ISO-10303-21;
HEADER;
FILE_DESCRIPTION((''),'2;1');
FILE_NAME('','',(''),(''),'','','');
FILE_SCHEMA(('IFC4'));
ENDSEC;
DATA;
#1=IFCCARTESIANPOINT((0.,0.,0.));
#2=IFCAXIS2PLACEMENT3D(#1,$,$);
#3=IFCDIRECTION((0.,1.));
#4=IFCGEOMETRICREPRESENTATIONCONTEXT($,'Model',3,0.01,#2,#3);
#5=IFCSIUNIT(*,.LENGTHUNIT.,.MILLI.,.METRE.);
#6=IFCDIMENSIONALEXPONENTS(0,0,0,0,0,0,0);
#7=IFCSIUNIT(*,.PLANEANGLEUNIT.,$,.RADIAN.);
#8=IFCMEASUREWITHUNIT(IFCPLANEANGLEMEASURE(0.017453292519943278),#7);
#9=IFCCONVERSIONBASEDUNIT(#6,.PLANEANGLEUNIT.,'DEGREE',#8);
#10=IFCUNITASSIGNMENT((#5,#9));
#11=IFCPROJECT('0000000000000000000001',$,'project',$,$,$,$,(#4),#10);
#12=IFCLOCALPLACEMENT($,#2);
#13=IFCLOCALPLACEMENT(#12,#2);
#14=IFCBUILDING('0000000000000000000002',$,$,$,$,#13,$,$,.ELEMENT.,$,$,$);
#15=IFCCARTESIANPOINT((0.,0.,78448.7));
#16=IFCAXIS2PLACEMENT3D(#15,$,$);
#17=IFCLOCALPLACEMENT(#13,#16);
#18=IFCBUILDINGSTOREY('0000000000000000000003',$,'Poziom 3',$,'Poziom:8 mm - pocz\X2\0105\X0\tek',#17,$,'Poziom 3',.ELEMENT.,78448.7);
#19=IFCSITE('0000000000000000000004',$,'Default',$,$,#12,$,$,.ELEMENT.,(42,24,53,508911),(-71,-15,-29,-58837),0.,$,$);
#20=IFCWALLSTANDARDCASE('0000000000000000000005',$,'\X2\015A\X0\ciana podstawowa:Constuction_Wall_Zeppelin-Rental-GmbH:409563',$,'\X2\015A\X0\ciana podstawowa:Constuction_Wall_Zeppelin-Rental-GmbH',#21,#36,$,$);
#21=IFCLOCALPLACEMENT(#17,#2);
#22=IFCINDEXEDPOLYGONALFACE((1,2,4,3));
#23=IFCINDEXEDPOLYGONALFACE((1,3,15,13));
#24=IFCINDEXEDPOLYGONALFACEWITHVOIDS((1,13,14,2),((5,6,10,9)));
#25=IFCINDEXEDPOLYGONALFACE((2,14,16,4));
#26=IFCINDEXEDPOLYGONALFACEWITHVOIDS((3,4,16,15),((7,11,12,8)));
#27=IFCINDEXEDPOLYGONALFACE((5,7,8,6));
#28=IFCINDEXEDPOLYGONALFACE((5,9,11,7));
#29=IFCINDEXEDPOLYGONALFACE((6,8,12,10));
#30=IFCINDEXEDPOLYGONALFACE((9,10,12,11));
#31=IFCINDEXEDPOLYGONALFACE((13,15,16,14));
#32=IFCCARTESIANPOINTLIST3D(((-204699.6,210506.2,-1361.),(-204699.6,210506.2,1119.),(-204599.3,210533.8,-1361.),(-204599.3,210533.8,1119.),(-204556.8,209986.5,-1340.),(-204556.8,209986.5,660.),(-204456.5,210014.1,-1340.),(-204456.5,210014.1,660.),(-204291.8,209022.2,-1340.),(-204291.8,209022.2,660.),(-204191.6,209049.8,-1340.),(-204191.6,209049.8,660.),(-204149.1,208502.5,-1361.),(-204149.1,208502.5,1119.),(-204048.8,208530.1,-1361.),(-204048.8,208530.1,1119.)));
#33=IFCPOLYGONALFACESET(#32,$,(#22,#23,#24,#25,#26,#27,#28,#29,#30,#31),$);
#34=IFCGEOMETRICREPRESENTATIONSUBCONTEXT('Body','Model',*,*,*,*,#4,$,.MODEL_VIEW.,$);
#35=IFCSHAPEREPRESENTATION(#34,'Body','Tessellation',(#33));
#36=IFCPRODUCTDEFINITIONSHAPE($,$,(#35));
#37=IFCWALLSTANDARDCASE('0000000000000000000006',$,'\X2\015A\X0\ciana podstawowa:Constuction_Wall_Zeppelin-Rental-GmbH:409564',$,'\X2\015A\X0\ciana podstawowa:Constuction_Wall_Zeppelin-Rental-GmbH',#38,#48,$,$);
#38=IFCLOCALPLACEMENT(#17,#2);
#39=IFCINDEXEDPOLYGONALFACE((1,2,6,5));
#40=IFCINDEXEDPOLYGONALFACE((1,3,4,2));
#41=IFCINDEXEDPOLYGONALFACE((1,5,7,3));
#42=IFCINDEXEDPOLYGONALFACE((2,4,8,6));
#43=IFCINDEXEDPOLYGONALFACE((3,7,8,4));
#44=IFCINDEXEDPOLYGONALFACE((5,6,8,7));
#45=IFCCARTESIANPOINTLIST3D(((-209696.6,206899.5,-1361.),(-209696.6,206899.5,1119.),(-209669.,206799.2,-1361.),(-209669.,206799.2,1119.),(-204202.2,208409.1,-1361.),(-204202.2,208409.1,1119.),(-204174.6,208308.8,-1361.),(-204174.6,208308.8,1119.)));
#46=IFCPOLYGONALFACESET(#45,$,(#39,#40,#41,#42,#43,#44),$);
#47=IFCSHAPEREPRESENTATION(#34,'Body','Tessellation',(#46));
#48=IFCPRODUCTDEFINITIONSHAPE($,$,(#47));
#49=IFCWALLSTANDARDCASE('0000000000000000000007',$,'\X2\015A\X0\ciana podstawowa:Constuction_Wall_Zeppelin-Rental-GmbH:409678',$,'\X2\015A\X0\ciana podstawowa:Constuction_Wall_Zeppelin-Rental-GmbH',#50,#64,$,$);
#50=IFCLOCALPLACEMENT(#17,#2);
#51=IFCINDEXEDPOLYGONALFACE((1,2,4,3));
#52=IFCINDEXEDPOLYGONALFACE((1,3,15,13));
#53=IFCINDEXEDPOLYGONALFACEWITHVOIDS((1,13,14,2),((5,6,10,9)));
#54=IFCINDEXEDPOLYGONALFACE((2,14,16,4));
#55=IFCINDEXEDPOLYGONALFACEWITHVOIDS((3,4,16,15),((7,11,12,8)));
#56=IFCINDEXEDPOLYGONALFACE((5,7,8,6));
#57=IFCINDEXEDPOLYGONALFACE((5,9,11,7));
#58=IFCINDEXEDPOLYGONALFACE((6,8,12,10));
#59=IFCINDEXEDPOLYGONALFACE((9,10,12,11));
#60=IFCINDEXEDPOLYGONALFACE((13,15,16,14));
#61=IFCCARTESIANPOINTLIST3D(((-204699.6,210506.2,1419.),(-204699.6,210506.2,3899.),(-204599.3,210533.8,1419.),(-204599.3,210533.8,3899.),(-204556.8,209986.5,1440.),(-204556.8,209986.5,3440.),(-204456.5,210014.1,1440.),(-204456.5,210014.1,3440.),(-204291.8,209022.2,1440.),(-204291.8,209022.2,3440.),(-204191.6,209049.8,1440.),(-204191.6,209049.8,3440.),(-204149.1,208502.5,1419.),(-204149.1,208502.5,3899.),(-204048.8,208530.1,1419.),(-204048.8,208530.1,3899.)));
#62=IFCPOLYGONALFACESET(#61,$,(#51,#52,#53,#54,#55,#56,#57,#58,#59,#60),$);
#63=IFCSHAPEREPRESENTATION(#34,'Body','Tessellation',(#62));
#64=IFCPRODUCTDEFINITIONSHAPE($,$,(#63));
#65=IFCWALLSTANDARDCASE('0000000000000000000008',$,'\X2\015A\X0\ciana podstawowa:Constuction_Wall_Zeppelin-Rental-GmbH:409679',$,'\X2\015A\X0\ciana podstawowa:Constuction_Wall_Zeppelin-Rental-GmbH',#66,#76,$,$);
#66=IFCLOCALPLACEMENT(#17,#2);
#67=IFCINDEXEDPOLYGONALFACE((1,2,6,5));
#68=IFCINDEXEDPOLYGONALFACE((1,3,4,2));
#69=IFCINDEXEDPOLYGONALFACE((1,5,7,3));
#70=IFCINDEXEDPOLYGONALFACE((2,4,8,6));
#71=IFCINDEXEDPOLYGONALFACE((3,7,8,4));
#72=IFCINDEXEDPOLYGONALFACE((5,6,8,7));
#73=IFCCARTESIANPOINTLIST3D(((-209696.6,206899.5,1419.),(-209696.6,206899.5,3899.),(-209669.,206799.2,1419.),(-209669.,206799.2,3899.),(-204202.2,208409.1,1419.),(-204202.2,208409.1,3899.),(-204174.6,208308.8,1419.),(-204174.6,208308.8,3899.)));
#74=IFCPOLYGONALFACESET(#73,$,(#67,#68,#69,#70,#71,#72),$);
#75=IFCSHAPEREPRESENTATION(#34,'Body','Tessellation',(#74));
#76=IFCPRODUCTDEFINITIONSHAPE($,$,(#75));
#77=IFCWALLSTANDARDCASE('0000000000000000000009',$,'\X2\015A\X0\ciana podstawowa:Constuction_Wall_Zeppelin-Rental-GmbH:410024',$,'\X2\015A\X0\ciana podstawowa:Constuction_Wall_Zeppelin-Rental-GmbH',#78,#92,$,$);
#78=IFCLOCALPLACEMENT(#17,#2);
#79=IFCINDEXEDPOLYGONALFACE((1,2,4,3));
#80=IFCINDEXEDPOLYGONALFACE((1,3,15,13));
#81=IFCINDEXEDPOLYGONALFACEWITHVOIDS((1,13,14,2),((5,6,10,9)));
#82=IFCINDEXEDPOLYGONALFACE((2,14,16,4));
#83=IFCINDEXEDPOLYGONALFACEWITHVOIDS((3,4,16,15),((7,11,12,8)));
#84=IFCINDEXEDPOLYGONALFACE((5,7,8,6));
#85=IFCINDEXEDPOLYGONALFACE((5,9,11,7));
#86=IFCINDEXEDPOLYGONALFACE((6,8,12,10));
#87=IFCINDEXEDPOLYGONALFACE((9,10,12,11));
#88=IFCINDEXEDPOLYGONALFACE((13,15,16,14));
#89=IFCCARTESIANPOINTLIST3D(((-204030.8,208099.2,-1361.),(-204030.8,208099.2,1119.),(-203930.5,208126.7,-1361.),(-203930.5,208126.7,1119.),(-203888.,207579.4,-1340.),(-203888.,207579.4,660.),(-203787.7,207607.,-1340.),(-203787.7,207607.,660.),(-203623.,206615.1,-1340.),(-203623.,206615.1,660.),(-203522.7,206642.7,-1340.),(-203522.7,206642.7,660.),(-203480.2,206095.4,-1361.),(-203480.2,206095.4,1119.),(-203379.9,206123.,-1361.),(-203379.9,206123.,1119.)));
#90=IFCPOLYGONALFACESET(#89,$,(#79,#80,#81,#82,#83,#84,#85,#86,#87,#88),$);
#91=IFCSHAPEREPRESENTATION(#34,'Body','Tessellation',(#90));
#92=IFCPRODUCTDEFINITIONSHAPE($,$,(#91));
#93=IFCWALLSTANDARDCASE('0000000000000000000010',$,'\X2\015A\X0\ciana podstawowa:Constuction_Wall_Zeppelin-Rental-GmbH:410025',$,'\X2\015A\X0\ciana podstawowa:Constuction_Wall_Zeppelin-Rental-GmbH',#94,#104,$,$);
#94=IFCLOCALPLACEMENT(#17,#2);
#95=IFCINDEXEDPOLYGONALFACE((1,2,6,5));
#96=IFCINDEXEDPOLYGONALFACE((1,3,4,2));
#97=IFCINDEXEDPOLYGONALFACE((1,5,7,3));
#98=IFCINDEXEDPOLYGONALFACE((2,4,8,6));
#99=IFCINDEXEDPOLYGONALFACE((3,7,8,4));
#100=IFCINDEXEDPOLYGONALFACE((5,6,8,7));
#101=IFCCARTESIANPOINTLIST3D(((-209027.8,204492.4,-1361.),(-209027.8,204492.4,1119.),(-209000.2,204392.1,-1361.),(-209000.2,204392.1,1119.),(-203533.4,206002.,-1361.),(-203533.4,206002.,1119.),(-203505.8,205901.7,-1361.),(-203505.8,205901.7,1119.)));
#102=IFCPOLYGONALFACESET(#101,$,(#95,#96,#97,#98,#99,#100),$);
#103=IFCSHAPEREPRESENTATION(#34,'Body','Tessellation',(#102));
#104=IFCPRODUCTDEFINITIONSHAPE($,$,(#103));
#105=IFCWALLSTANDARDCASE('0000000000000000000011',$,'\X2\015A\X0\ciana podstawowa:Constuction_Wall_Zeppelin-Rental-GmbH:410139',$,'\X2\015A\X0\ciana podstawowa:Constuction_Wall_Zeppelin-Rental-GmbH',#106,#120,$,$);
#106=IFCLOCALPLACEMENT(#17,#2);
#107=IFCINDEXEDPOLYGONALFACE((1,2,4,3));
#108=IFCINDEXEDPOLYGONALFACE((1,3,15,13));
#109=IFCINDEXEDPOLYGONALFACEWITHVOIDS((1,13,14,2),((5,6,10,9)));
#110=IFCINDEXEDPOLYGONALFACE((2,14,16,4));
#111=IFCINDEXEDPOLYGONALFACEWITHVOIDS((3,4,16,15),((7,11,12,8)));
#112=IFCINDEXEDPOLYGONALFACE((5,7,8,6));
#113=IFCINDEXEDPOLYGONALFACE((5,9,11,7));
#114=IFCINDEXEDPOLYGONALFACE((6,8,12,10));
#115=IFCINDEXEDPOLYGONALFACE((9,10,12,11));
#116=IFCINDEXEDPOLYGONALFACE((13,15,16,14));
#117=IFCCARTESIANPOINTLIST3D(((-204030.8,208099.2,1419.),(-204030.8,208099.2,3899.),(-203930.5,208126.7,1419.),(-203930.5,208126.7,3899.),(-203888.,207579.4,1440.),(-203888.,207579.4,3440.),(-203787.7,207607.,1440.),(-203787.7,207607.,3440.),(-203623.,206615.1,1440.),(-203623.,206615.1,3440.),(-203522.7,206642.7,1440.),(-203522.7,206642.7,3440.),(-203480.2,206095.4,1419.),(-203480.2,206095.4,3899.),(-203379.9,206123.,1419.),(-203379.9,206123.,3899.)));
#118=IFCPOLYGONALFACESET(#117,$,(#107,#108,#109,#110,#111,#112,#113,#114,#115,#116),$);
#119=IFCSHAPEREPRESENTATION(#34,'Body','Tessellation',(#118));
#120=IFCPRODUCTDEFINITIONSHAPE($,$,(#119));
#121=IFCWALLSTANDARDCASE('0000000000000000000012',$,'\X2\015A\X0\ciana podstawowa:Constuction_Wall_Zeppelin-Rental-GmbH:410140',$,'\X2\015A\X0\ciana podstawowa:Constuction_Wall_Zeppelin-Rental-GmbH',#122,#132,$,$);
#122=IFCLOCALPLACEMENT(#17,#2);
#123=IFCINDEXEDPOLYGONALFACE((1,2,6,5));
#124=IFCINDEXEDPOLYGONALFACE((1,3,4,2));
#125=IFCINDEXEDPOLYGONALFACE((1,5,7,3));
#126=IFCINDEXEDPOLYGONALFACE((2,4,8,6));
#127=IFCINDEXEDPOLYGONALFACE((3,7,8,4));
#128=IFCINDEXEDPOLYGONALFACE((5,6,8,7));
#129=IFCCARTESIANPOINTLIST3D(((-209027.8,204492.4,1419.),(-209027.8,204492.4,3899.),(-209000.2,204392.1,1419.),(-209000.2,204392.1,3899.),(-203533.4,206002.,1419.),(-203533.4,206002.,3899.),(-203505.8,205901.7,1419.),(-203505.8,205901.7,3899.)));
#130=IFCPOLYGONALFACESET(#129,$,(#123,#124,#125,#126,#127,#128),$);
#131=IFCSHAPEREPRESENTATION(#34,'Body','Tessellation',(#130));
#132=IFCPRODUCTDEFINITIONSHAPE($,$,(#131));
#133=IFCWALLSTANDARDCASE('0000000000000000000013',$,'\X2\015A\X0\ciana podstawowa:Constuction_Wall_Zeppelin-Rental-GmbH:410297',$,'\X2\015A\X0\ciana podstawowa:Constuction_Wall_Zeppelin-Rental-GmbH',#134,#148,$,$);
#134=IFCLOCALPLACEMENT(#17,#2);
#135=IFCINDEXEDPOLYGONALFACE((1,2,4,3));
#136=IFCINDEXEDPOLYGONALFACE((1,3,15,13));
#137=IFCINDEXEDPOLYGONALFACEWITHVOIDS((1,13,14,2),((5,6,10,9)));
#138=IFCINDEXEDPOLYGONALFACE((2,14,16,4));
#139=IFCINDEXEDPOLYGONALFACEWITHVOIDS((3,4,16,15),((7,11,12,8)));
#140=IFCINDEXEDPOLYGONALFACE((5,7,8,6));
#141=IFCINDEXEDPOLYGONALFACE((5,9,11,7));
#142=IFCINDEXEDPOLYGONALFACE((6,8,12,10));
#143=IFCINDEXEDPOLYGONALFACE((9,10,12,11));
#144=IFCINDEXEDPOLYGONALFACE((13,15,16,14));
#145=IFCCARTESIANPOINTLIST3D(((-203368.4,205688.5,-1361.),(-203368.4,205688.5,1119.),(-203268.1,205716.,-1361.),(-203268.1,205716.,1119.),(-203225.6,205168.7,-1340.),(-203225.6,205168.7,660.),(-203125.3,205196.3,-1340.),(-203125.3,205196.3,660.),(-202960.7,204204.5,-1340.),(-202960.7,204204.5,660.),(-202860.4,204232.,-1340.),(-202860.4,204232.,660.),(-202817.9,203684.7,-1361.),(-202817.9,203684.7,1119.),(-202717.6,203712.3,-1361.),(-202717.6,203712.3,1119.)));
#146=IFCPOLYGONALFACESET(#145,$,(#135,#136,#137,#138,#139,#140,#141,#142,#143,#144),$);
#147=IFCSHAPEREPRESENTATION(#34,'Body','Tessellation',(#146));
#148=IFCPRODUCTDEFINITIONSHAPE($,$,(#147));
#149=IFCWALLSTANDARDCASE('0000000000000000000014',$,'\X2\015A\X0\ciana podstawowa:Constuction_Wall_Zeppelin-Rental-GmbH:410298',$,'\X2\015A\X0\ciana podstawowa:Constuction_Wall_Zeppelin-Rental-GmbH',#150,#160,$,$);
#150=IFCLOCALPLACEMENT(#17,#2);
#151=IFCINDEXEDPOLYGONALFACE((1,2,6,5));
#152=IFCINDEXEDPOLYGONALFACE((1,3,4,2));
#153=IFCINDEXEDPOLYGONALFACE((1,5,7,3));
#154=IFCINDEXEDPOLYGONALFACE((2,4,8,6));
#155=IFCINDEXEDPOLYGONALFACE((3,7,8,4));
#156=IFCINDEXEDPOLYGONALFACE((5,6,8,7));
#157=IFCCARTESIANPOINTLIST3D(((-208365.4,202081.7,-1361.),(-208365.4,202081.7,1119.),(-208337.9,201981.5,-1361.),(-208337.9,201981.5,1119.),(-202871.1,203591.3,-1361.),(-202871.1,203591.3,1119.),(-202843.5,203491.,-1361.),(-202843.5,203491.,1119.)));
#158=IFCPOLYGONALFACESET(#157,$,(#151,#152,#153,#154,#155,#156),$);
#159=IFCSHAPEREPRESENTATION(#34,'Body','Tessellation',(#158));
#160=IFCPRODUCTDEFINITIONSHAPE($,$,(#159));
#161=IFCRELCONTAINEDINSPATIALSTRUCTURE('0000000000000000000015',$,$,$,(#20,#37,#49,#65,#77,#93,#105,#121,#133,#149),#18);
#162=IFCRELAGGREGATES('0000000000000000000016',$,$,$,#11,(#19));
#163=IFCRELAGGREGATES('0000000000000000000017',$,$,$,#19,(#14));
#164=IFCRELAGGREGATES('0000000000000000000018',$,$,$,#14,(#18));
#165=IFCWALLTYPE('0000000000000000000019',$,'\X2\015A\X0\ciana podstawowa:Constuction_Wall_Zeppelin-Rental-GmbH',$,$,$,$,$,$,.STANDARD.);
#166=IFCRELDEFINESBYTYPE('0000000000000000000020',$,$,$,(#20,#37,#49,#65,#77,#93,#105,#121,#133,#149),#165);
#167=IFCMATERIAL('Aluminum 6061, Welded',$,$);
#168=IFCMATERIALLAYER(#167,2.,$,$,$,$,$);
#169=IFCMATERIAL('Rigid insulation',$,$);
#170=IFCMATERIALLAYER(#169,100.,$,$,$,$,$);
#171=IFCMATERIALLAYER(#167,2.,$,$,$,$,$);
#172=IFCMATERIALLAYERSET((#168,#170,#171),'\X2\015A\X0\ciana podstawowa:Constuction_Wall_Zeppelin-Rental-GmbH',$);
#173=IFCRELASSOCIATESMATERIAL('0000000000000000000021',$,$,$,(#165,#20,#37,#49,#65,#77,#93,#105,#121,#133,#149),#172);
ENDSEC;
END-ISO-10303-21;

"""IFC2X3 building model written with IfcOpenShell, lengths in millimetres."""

from ifc_helpers import new_model, entity, si_unit, converted_unit, direction, frame, frame_2d, origin, place, context, subcontext, project, spatial, rectangle, extrude, material, layer, layer_set, layer_usage, type_object, element, save


model = new_model("IFC2X3")

# Units and contexts
model_context = context("Model", 3, precision=0.01, world=origin(), true_north=direction((0.0, 1.0)))
body_context = subcontext(model_context, "Body", "Model", "MODEL_VIEW")
ifc_project = project(units=[si_unit("LENGTHUNIT", "METRE", prefix="MILLI"), converted_unit("PLANEANGLEUNIT", "DEGREE", entity("IfcPlaneAngleMeasure", 0.017453292519943278), si_unit("PLANEANGLEUNIT", "RADIAN"), dimensions=[0, 0, 0, 0, 0, 0, 0])], contexts=[model_context])

# Site, building, storey
site_placement = place(None, origin())
site = spatial("IfcSite", under=ifc_project, at=site_placement, Name="Default", CompositionType="ELEMENT", RefLatitude=(42, 24, 53, 508911), RefLongitude=(-71, -15, -29, -58837), RefElevation=0.0)
building_placement = place(site_placement, origin())
building = spatial("IfcBuilding", under=site, at=building_placement, CompositionType="ELEMENT")
storey_placement = place(building_placement, frame((0.0, 0.0, 78448.7)))
storey = spatial("IfcBuildingStorey", under=building, at=storey_placement, Name="Poziom 3", ObjectType="Poziom:8 mm - początek", LongName="Poziom 3", CompositionType="ELEMENT", Elevation=78448.7)

# Wall, opening
ifc_material_1 = material(Name="Aluminum 6061, Welded")
ifc_layer_1 = layer(ifc_material_1, 2.0)
ifc_material_2 = material(Name="Rigid insulation")
ifc_layer_2 = layer(ifc_material_2, 100.0)
ifc_layer_3 = layer(ifc_material_1, 2.0)
ifc_layer_set = layer_set([ifc_layer_1, ifc_layer_2, ifc_layer_3], Name="Ściana podstawowa:Constuction_Wall_Zeppelin-Rental-GmbH")
ifc_layer_usage_1 = layer_usage(ifc_layer_set, "AXIS2", "NEGATIVE", 52.0)
wall_type = type_object("IfcWallType", Name="Ściana podstawowa:Constuction_Wall_Zeppelin-Rental-GmbH", PredefinedType="STANDARD", material=ifc_layer_set)
wall_1_placement = place(storey_placement, frame((-204649.4, 210520.0, -1361.0), z_axis=(0.0, 0.0, 1.0), x_axis=(0.264931, -0.964267, 0.0)))
wall_1 = element("IfcWallStandardCase", 1, at=wall_1_placement, inside=storey, type_object=wall_type, material=ifc_layer_usage_1, Name="Ściana podstawowa:Constuction_Wall_Zeppelin-Rental-GmbH:409563", ObjectType="Ściana podstawowa:Constuction_Wall_Zeppelin-Rental-GmbH", context=body_context, shape_type="SweptSolid", body=[
    extrude(rectangle(XDim=2078.0, YDim=104.0, at=frame_2d((1039.0, 0.0), x_axis=(-1.0, 0.0))), origin(), (0.0, 0.0, 1.0), 2480.0),
])
opening_1_placement = place(wall_1_placement, frame((539.0, -52.0, 21.0)))
element("IfcOpeningElement", 2, at=opening_1_placement, cuts=wall_1, ObjectType="Opening", context=body_context, shape_type="SweptSolid", body=[
    extrude(rectangle(XDim=2000.0, YDim=1000.0, at=frame_2d((1000.0, 500.0), x_axis=(1.0, 0.0))), frame((0.0, 0.0, 0.0), z_axis=(0.0, 1.0, 0.0), x_axis=(0.0, 0.0, 1.0)), (0.0, 0.0, 1.0), 104.0),
])

# Wall
ifc_layer_usage_2 = layer_usage(ifc_layer_set, "AXIS2", "NEGATIVE", 52.0)
wall_2_placement = place(storey_placement, frame((-204188.4, 208358.9, -1361.0), z_axis=(0.0, 0.0, 1.0), x_axis=(-0.964267, -0.264931, 0.0)))
element("IfcWallStandardCase", 3, at=wall_2_placement, inside=storey, type_object=wall_type, material=ifc_layer_usage_2, Name="Ściana podstawowa:Constuction_Wall_Zeppelin-Rental-GmbH:409564", ObjectType="Ściana podstawowa:Constuction_Wall_Zeppelin-Rental-GmbH", context=body_context, shape_type="SweptSolid", body=[
    extrude(rectangle(XDim=5698.0, YDim=104.0, at=frame_2d((2849.0, 0.0), x_axis=(-1.0, 0.0))), origin(), (0.0, 0.0, 1.0), 2480.0),
])

# Wall, opening
ifc_layer_usage_3 = layer_usage(ifc_layer_set, "AXIS2", "NEGATIVE", 52.0)
wall_3_placement = place(storey_placement, frame((-204649.4, 210520.0, 1419.0), z_axis=(0.0, 0.0, 1.0), x_axis=(0.264931, -0.964267, 0.0)))
wall_3 = element("IfcWallStandardCase", 4, at=wall_3_placement, inside=storey, type_object=wall_type, material=ifc_layer_usage_3, Name="Ściana podstawowa:Constuction_Wall_Zeppelin-Rental-GmbH:409678", ObjectType="Ściana podstawowa:Constuction_Wall_Zeppelin-Rental-GmbH", context=body_context, shape_type="SweptSolid", body=[
    extrude(rectangle(XDim=2078.0, YDim=104.0, at=frame_2d((1039.0, 0.0), x_axis=(-1.0, 0.0))), origin(), (0.0, 0.0, 1.0), 2480.0),
])
opening_2_placement = place(wall_3_placement, frame((539.0, -52.0, 21.0)))
element("IfcOpeningElement", 5, at=opening_2_placement, cuts=wall_3, ObjectType="Opening", context=body_context, shape_type="SweptSolid", body=[
    extrude(rectangle(XDim=2000.0, YDim=1000.0, at=frame_2d((1000.0, 500.0), x_axis=(1.0, 0.0))), frame((0.0, 0.0, 0.0), z_axis=(0.0, 1.0, 0.0), x_axis=(0.0, 0.0, 1.0)), (0.0, 0.0, 1.0), 104.0),
])

# Wall
ifc_layer_usage_4 = layer_usage(ifc_layer_set, "AXIS2", "NEGATIVE", 52.0)
wall_4_placement = place(storey_placement, frame((-204188.4, 208358.9, 1419.0), z_axis=(0.0, 0.0, 1.0), x_axis=(-0.964267, -0.264931, 0.0)))
element("IfcWallStandardCase", 6, at=wall_4_placement, inside=storey, type_object=wall_type, material=ifc_layer_usage_4, Name="Ściana podstawowa:Constuction_Wall_Zeppelin-Rental-GmbH:409679", ObjectType="Ściana podstawowa:Constuction_Wall_Zeppelin-Rental-GmbH", context=body_context, shape_type="SweptSolid", body=[
    extrude(rectangle(XDim=5698.0, YDim=104.0, at=frame_2d((2849.0, 0.0), x_axis=(-1.0, 0.0))), origin(), (0.0, 0.0, 1.0), 2480.0),
])

# Wall, opening
ifc_layer_usage_5 = layer_usage(ifc_layer_set, "AXIS2", "NEGATIVE", 52.0)
wall_5_placement = place(storey_placement, frame((-203980.6, 208112.9, -1361.0), z_axis=(0.0, 0.0, 1.0), x_axis=(0.264931, -0.964267, 0.0)))
wall_5 = element("IfcWallStandardCase", 7, at=wall_5_placement, inside=storey, type_object=wall_type, material=ifc_layer_usage_5, Name="Ściana podstawowa:Constuction_Wall_Zeppelin-Rental-GmbH:410024", ObjectType="Ściana podstawowa:Constuction_Wall_Zeppelin-Rental-GmbH", context=body_context, shape_type="SweptSolid", body=[
    extrude(rectangle(XDim=2078.0, YDim=104.0, at=frame_2d((1039.0, 0.0), x_axis=(-1.0, 0.0))), origin(), (0.0, 0.0, 1.0), 2480.0),
])
opening_3_placement = place(wall_5_placement, frame((539.0, -52.0, 21.0)))
element("IfcOpeningElement", 8, at=opening_3_placement, cuts=wall_5, ObjectType="Opening", context=body_context, shape_type="SweptSolid", body=[
    extrude(rectangle(XDim=2000.0, YDim=1000.0, at=frame_2d((1000.0, 500.0), x_axis=(1.0, 0.0))), frame((0.0, 0.0, 0.0), z_axis=(0.0, 1.0, 0.0), x_axis=(0.0, 0.0, 1.0)), (0.0, 0.0, 1.0), 104.0),
])

# Wall
ifc_layer_usage_6 = layer_usage(ifc_layer_set, "AXIS2", "NEGATIVE", 52.0)
wall_6_placement = place(storey_placement, frame((-203519.6, 205951.8, -1361.0), z_axis=(0.0, 0.0, 1.0), x_axis=(-0.964267, -0.264931, 0.0)))
element("IfcWallStandardCase", 9, at=wall_6_placement, inside=storey, type_object=wall_type, material=ifc_layer_usage_6, Name="Ściana podstawowa:Constuction_Wall_Zeppelin-Rental-GmbH:410025", ObjectType="Ściana podstawowa:Constuction_Wall_Zeppelin-Rental-GmbH", context=body_context, shape_type="SweptSolid", body=[
    extrude(rectangle(XDim=5698.0, YDim=104.0, at=frame_2d((2849.0, 0.0), x_axis=(-1.0, 0.0))), origin(), (0.0, 0.0, 1.0), 2480.0),
])

# Wall, opening
ifc_layer_usage_7 = layer_usage(ifc_layer_set, "AXIS2", "NEGATIVE", 52.0)
wall_7_placement = place(storey_placement, frame((-203980.6, 208112.9, 1419.0), z_axis=(0.0, 0.0, 1.0), x_axis=(0.264931, -0.964267, 0.0)))
wall_7 = element("IfcWallStandardCase", 10, at=wall_7_placement, inside=storey, type_object=wall_type, material=ifc_layer_usage_7, Name="Ściana podstawowa:Constuction_Wall_Zeppelin-Rental-GmbH:410139", ObjectType="Ściana podstawowa:Constuction_Wall_Zeppelin-Rental-GmbH", context=body_context, shape_type="SweptSolid", body=[
    extrude(rectangle(XDim=2078.0, YDim=104.0, at=frame_2d((1039.0, 0.0), x_axis=(-1.0, 0.0))), origin(), (0.0, 0.0, 1.0), 2480.0),
])
opening_4_placement = place(wall_7_placement, frame((539.0, -52.0, 21.0)))
element("IfcOpeningElement", 11, at=opening_4_placement, cuts=wall_7, ObjectType="Opening", context=body_context, shape_type="SweptSolid", body=[
    extrude(rectangle(XDim=2000.0, YDim=1000.0, at=frame_2d((1000.0, 500.0), x_axis=(1.0, 0.0))), frame((0.0, 0.0, 0.0), z_axis=(0.0, 1.0, 0.0), x_axis=(0.0, 0.0, 1.0)), (0.0, 0.0, 1.0), 104.0),
])

# Wall
ifc_layer_usage_8 = layer_usage(ifc_layer_set, "AXIS2", "NEGATIVE", 52.0)
wall_8_placement = place(storey_placement, frame((-203519.6, 205951.8, 1419.0), z_axis=(0.0, 0.0, 1.0), x_axis=(-0.964267, -0.264931, 0.0)))
element("IfcWallStandardCase", 12, at=wall_8_placement, inside=storey, type_object=wall_type, material=ifc_layer_usage_8, Name="Ściana podstawowa:Constuction_Wall_Zeppelin-Rental-GmbH:410140", ObjectType="Ściana podstawowa:Constuction_Wall_Zeppelin-Rental-GmbH", context=body_context, shape_type="SweptSolid", body=[
    extrude(rectangle(XDim=5698.0, YDim=104.0, at=frame_2d((2849.0, 0.0), x_axis=(-1.0, 0.0))), origin(), (0.0, 0.0, 1.0), 2480.0),
])

# Wall, opening
ifc_layer_usage_9 = layer_usage(ifc_layer_set, "AXIS2", "NEGATIVE", 52.0)
wall_9_placement = place(storey_placement, frame((-203318.3, 205702.3, -1361.0), z_axis=(0.0, 0.0, 1.0), x_axis=(0.264931, -0.964267, 0.0)))
wall_9 = element("IfcWallStandardCase", 13, at=wall_9_placement, inside=storey, type_object=wall_type, material=ifc_layer_usage_9, Name="Ściana podstawowa:Constuction_Wall_Zeppelin-Rental-GmbH:410297", ObjectType="Ściana podstawowa:Constuction_Wall_Zeppelin-Rental-GmbH", context=body_context, shape_type="SweptSolid", body=[
    extrude(rectangle(XDim=2078.0, YDim=104.0, at=frame_2d((1039.0, 0.0), x_axis=(-1.0, 0.0))), origin(), (0.0, 0.0, 1.0), 2480.0),
])
opening_5_placement = place(wall_9_placement, frame((539.0, -52.0, 21.0)))
element("IfcOpeningElement", 14, at=opening_5_placement, cuts=wall_9, ObjectType="Opening", context=body_context, shape_type="SweptSolid", body=[
    extrude(rectangle(XDim=2000.0, YDim=1000.0, at=frame_2d((1000.0, 500.0), x_axis=(1.0, 0.0))), frame((0.0, 0.0, 0.0), z_axis=(0.0, 1.0, 0.0), x_axis=(0.0, 0.0, 1.0)), (0.0, 0.0, 1.0), 104.0),
])

# Wall
ifc_layer_usage_10 = layer_usage(ifc_layer_set, "AXIS2", "NEGATIVE", 52.0)
wall_10_placement = place(storey_placement, frame((-202857.3, 203541.2, -1361.0), z_axis=(0.0, 0.0, 1.0), x_axis=(-0.964267, -0.264931, 0.0)))
element("IfcWallStandardCase", 15, at=wall_10_placement, inside=storey, type_object=wall_type, material=ifc_layer_usage_10, Name="Ściana podstawowa:Constuction_Wall_Zeppelin-Rental-GmbH:410298", ObjectType="Ściana podstawowa:Constuction_Wall_Zeppelin-Rental-GmbH", context=body_context, shape_type="SweptSolid", body=[
    extrude(rectangle(XDim=5698.0, YDim=104.0, at=frame_2d((2849.0, 0.0), x_axis=(-1.0, 0.0))), origin(), (0.0, 0.0, 1.0), 2480.0),
])

save(model, "model.ifc")
